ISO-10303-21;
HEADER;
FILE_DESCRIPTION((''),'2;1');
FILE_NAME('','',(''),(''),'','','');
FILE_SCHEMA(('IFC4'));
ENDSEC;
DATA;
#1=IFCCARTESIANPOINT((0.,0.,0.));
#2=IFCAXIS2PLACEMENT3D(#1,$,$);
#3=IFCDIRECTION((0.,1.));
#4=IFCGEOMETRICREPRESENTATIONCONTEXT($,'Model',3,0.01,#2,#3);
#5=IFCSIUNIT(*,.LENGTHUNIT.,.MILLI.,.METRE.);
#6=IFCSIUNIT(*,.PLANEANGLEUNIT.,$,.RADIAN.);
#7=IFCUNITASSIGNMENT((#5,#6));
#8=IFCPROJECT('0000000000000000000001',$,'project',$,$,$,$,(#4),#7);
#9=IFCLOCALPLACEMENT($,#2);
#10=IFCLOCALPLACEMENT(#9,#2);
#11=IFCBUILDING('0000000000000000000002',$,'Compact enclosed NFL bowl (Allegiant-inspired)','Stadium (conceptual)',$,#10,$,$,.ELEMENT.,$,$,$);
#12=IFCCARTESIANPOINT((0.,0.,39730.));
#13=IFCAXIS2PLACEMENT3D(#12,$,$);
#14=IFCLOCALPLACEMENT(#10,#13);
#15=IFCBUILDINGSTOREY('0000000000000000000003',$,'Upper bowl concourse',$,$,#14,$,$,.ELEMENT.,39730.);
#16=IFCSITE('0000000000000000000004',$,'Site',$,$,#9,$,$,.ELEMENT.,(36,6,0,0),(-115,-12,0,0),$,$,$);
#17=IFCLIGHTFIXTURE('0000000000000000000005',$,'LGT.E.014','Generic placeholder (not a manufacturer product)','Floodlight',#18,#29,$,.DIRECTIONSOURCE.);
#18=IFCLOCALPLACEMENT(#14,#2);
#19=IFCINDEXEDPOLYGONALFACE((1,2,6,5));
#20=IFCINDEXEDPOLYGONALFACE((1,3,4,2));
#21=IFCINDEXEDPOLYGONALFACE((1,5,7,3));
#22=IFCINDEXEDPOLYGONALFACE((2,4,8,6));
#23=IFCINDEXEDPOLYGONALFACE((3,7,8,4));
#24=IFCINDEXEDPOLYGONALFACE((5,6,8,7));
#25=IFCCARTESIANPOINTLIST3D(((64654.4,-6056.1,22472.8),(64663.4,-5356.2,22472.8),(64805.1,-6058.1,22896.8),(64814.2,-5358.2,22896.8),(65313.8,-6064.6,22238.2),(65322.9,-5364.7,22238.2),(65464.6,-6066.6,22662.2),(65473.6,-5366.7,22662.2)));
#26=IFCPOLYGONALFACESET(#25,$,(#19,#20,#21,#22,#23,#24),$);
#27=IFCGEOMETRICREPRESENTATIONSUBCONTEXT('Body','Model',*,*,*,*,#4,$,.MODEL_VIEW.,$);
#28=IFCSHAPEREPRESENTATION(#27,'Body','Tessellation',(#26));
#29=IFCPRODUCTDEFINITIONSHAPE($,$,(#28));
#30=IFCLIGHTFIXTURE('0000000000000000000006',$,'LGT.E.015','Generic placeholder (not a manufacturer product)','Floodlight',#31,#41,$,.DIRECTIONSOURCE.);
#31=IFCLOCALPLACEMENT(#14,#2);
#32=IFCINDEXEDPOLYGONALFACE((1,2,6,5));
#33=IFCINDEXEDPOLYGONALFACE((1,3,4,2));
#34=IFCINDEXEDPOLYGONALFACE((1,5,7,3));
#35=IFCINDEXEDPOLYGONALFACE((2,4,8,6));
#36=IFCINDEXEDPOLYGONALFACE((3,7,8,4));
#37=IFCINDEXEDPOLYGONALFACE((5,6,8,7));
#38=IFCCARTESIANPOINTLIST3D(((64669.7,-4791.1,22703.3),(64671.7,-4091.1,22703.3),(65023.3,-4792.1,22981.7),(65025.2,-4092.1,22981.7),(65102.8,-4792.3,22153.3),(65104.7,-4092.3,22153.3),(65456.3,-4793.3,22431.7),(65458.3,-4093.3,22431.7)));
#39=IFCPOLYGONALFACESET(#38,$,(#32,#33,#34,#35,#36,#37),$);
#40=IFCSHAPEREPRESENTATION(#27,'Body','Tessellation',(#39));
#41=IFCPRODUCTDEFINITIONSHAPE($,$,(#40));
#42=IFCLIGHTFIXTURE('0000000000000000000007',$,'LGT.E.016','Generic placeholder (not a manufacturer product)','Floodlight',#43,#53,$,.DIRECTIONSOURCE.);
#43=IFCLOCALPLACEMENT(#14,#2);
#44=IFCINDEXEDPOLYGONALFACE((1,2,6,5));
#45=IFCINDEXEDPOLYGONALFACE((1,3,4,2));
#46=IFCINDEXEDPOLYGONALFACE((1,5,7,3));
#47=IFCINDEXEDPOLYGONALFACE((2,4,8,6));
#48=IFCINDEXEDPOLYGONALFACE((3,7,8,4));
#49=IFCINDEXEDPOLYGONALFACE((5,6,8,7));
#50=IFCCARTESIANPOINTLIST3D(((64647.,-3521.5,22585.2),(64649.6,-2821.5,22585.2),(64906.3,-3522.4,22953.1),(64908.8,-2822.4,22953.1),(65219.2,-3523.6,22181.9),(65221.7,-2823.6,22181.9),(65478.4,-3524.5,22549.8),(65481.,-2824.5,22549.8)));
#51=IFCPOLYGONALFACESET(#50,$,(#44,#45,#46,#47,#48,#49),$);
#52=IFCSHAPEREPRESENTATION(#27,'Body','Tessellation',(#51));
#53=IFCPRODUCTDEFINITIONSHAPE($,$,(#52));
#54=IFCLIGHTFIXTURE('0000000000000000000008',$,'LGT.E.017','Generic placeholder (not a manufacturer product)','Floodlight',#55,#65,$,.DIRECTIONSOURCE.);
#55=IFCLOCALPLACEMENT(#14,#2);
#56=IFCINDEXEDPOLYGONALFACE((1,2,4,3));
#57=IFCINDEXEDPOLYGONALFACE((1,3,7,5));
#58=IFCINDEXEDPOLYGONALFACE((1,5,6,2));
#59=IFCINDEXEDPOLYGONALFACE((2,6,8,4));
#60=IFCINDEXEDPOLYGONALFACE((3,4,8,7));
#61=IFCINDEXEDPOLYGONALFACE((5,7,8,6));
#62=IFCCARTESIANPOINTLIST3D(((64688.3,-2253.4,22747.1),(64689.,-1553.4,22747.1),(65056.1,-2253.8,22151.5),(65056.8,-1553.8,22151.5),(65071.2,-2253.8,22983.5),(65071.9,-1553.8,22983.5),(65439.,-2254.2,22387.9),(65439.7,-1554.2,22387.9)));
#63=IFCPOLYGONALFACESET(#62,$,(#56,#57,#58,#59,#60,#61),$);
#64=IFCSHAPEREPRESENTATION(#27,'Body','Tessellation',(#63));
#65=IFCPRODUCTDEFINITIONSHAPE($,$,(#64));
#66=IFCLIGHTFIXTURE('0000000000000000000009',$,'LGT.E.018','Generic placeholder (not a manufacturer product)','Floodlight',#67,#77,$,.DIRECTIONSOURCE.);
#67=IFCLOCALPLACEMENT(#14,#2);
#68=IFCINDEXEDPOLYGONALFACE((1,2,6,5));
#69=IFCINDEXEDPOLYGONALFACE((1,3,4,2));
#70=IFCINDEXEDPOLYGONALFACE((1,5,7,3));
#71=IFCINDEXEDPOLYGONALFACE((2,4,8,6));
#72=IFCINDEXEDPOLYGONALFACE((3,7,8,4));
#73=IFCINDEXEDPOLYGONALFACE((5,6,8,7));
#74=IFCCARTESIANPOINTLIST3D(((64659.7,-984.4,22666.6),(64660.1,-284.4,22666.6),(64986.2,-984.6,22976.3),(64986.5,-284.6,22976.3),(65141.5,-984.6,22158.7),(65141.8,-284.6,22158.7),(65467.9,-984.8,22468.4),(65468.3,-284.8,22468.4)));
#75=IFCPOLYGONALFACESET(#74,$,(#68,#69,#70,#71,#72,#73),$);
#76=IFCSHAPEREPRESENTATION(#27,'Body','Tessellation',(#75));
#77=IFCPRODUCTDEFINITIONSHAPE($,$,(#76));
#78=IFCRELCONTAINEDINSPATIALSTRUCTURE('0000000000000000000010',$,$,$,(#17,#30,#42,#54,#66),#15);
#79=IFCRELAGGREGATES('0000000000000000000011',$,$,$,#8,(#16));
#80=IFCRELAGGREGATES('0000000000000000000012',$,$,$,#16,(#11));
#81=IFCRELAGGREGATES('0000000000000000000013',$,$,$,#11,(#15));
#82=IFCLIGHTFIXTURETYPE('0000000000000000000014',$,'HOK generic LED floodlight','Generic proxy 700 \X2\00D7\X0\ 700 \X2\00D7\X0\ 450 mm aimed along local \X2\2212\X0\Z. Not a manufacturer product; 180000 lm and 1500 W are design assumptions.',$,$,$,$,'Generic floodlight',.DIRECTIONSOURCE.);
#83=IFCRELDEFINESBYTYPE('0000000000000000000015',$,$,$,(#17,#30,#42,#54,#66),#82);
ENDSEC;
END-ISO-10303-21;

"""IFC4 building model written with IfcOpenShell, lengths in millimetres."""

from ifc_helpers import new_model, si_unit, direction, frame, origin, place, context, subcontext, project, spatial, rectangle, extrude, source, transform, mapped, type_object, type_shapes, element, save


model = new_model("IFC4")

# Units and contexts
model_context = context("Model", 3, precision=0.01, world=origin(), true_north=direction((0.0, 1.0)))
body_context = subcontext(model_context, "Body", "Model", "MODEL_VIEW")
ifc_project = project(units=[si_unit("LENGTHUNIT", "METRE", prefix="MILLI"), si_unit("PLANEANGLEUNIT", "RADIAN")], contexts=[model_context])

# Site, building, storey
site_placement = place(None, origin())
site = spatial("IfcSite", under=ifc_project, at=site_placement, Name="Site", CompositionType="ELEMENT", RefLatitude=(36, 6, 0, 0), RefLongitude=(-115, -12, 0, 0))
building_placement = place(site_placement, origin())
building = spatial("IfcBuilding", under=site, at=building_placement, Name="Compact enclosed NFL bowl (Allegiant-inspired)", Description="Stadium (conceptual)", CompositionType="ELEMENT")
storey_placement = place(building_placement, frame((0.0, 0.0, 39730.0)))
storey = spatial("IfcBuildingStorey", under=building, at=storey_placement, Name="Upper bowl concourse", CompositionType="ELEMENT", Elevation=39730.0)

# Light fixtures
light_fixture_type = type_object("IfcLightFixtureType", Name="HOK generic LED floodlight", Description="Generic proxy 700 × 700 × 450 mm aimed along local −Z. Not a manufacturer product; 180000 lm and 1500 W are design assumptions.", ElementType="Generic floodlight", PredefinedType="DIRECTIONSOURCE")
shared_shape = source(origin(), body_context, "Body", "SweptSolid", [
    extrude(rectangle(XDim=700.0, YDim=700.0), frame((0.0, 0.0, -225.0)), (0.0, 0.0, 1.0), 450.0),
])
type_shapes(light_fixture_type, [shared_shape])
for number, where, z_axis, x_axis, name in (
    (1, (65064.0, -5711.4, 22567.5), (0.335041, -0.004319, 0.942194), (0.01289, 0.999917, 0.0), "LGT.E.014"),
    (2, (65064.0, -4442.2, 22567.5), (0.785672, -0.002206, 0.618639), (0.002807, 0.999996, 0.0), "LGT.E.015"),
    (3, (65064.0, -3173.0, 22567.5), (0.576129, -0.002082, 0.817356), (0.003613, 0.999993, 0.0), "LGT.E.016"),
    (4, (65064.0, -1903.8, 22567.5), (0.850831, -0.000803, 0.52544), (0.000944, 1.0, 0.0), "LGT.E.017"),
    (5, (65064.0, -634.6, 22567.5), (0.725492, -0.000351, 0.688231), (0.000483, 1.0, 0.0), "LGT.E.018"),
):
    element("IfcLightFixture", number, at=place(storey_placement, frame(where, z_axis=z_axis, x_axis=x_axis)), inside=storey, type_object=light_fixture_type, Name=name, Description="Generic placeholder (not a manufacturer product)", ObjectType="Floodlight", PredefinedType="DIRECTIONSOURCE", context=body_context, shape_type="MappedRepresentation", body=[
        mapped(shared_shape, transform((0.0, 0.0, 0.0))),
    ])

save(model, "model.ifc")
